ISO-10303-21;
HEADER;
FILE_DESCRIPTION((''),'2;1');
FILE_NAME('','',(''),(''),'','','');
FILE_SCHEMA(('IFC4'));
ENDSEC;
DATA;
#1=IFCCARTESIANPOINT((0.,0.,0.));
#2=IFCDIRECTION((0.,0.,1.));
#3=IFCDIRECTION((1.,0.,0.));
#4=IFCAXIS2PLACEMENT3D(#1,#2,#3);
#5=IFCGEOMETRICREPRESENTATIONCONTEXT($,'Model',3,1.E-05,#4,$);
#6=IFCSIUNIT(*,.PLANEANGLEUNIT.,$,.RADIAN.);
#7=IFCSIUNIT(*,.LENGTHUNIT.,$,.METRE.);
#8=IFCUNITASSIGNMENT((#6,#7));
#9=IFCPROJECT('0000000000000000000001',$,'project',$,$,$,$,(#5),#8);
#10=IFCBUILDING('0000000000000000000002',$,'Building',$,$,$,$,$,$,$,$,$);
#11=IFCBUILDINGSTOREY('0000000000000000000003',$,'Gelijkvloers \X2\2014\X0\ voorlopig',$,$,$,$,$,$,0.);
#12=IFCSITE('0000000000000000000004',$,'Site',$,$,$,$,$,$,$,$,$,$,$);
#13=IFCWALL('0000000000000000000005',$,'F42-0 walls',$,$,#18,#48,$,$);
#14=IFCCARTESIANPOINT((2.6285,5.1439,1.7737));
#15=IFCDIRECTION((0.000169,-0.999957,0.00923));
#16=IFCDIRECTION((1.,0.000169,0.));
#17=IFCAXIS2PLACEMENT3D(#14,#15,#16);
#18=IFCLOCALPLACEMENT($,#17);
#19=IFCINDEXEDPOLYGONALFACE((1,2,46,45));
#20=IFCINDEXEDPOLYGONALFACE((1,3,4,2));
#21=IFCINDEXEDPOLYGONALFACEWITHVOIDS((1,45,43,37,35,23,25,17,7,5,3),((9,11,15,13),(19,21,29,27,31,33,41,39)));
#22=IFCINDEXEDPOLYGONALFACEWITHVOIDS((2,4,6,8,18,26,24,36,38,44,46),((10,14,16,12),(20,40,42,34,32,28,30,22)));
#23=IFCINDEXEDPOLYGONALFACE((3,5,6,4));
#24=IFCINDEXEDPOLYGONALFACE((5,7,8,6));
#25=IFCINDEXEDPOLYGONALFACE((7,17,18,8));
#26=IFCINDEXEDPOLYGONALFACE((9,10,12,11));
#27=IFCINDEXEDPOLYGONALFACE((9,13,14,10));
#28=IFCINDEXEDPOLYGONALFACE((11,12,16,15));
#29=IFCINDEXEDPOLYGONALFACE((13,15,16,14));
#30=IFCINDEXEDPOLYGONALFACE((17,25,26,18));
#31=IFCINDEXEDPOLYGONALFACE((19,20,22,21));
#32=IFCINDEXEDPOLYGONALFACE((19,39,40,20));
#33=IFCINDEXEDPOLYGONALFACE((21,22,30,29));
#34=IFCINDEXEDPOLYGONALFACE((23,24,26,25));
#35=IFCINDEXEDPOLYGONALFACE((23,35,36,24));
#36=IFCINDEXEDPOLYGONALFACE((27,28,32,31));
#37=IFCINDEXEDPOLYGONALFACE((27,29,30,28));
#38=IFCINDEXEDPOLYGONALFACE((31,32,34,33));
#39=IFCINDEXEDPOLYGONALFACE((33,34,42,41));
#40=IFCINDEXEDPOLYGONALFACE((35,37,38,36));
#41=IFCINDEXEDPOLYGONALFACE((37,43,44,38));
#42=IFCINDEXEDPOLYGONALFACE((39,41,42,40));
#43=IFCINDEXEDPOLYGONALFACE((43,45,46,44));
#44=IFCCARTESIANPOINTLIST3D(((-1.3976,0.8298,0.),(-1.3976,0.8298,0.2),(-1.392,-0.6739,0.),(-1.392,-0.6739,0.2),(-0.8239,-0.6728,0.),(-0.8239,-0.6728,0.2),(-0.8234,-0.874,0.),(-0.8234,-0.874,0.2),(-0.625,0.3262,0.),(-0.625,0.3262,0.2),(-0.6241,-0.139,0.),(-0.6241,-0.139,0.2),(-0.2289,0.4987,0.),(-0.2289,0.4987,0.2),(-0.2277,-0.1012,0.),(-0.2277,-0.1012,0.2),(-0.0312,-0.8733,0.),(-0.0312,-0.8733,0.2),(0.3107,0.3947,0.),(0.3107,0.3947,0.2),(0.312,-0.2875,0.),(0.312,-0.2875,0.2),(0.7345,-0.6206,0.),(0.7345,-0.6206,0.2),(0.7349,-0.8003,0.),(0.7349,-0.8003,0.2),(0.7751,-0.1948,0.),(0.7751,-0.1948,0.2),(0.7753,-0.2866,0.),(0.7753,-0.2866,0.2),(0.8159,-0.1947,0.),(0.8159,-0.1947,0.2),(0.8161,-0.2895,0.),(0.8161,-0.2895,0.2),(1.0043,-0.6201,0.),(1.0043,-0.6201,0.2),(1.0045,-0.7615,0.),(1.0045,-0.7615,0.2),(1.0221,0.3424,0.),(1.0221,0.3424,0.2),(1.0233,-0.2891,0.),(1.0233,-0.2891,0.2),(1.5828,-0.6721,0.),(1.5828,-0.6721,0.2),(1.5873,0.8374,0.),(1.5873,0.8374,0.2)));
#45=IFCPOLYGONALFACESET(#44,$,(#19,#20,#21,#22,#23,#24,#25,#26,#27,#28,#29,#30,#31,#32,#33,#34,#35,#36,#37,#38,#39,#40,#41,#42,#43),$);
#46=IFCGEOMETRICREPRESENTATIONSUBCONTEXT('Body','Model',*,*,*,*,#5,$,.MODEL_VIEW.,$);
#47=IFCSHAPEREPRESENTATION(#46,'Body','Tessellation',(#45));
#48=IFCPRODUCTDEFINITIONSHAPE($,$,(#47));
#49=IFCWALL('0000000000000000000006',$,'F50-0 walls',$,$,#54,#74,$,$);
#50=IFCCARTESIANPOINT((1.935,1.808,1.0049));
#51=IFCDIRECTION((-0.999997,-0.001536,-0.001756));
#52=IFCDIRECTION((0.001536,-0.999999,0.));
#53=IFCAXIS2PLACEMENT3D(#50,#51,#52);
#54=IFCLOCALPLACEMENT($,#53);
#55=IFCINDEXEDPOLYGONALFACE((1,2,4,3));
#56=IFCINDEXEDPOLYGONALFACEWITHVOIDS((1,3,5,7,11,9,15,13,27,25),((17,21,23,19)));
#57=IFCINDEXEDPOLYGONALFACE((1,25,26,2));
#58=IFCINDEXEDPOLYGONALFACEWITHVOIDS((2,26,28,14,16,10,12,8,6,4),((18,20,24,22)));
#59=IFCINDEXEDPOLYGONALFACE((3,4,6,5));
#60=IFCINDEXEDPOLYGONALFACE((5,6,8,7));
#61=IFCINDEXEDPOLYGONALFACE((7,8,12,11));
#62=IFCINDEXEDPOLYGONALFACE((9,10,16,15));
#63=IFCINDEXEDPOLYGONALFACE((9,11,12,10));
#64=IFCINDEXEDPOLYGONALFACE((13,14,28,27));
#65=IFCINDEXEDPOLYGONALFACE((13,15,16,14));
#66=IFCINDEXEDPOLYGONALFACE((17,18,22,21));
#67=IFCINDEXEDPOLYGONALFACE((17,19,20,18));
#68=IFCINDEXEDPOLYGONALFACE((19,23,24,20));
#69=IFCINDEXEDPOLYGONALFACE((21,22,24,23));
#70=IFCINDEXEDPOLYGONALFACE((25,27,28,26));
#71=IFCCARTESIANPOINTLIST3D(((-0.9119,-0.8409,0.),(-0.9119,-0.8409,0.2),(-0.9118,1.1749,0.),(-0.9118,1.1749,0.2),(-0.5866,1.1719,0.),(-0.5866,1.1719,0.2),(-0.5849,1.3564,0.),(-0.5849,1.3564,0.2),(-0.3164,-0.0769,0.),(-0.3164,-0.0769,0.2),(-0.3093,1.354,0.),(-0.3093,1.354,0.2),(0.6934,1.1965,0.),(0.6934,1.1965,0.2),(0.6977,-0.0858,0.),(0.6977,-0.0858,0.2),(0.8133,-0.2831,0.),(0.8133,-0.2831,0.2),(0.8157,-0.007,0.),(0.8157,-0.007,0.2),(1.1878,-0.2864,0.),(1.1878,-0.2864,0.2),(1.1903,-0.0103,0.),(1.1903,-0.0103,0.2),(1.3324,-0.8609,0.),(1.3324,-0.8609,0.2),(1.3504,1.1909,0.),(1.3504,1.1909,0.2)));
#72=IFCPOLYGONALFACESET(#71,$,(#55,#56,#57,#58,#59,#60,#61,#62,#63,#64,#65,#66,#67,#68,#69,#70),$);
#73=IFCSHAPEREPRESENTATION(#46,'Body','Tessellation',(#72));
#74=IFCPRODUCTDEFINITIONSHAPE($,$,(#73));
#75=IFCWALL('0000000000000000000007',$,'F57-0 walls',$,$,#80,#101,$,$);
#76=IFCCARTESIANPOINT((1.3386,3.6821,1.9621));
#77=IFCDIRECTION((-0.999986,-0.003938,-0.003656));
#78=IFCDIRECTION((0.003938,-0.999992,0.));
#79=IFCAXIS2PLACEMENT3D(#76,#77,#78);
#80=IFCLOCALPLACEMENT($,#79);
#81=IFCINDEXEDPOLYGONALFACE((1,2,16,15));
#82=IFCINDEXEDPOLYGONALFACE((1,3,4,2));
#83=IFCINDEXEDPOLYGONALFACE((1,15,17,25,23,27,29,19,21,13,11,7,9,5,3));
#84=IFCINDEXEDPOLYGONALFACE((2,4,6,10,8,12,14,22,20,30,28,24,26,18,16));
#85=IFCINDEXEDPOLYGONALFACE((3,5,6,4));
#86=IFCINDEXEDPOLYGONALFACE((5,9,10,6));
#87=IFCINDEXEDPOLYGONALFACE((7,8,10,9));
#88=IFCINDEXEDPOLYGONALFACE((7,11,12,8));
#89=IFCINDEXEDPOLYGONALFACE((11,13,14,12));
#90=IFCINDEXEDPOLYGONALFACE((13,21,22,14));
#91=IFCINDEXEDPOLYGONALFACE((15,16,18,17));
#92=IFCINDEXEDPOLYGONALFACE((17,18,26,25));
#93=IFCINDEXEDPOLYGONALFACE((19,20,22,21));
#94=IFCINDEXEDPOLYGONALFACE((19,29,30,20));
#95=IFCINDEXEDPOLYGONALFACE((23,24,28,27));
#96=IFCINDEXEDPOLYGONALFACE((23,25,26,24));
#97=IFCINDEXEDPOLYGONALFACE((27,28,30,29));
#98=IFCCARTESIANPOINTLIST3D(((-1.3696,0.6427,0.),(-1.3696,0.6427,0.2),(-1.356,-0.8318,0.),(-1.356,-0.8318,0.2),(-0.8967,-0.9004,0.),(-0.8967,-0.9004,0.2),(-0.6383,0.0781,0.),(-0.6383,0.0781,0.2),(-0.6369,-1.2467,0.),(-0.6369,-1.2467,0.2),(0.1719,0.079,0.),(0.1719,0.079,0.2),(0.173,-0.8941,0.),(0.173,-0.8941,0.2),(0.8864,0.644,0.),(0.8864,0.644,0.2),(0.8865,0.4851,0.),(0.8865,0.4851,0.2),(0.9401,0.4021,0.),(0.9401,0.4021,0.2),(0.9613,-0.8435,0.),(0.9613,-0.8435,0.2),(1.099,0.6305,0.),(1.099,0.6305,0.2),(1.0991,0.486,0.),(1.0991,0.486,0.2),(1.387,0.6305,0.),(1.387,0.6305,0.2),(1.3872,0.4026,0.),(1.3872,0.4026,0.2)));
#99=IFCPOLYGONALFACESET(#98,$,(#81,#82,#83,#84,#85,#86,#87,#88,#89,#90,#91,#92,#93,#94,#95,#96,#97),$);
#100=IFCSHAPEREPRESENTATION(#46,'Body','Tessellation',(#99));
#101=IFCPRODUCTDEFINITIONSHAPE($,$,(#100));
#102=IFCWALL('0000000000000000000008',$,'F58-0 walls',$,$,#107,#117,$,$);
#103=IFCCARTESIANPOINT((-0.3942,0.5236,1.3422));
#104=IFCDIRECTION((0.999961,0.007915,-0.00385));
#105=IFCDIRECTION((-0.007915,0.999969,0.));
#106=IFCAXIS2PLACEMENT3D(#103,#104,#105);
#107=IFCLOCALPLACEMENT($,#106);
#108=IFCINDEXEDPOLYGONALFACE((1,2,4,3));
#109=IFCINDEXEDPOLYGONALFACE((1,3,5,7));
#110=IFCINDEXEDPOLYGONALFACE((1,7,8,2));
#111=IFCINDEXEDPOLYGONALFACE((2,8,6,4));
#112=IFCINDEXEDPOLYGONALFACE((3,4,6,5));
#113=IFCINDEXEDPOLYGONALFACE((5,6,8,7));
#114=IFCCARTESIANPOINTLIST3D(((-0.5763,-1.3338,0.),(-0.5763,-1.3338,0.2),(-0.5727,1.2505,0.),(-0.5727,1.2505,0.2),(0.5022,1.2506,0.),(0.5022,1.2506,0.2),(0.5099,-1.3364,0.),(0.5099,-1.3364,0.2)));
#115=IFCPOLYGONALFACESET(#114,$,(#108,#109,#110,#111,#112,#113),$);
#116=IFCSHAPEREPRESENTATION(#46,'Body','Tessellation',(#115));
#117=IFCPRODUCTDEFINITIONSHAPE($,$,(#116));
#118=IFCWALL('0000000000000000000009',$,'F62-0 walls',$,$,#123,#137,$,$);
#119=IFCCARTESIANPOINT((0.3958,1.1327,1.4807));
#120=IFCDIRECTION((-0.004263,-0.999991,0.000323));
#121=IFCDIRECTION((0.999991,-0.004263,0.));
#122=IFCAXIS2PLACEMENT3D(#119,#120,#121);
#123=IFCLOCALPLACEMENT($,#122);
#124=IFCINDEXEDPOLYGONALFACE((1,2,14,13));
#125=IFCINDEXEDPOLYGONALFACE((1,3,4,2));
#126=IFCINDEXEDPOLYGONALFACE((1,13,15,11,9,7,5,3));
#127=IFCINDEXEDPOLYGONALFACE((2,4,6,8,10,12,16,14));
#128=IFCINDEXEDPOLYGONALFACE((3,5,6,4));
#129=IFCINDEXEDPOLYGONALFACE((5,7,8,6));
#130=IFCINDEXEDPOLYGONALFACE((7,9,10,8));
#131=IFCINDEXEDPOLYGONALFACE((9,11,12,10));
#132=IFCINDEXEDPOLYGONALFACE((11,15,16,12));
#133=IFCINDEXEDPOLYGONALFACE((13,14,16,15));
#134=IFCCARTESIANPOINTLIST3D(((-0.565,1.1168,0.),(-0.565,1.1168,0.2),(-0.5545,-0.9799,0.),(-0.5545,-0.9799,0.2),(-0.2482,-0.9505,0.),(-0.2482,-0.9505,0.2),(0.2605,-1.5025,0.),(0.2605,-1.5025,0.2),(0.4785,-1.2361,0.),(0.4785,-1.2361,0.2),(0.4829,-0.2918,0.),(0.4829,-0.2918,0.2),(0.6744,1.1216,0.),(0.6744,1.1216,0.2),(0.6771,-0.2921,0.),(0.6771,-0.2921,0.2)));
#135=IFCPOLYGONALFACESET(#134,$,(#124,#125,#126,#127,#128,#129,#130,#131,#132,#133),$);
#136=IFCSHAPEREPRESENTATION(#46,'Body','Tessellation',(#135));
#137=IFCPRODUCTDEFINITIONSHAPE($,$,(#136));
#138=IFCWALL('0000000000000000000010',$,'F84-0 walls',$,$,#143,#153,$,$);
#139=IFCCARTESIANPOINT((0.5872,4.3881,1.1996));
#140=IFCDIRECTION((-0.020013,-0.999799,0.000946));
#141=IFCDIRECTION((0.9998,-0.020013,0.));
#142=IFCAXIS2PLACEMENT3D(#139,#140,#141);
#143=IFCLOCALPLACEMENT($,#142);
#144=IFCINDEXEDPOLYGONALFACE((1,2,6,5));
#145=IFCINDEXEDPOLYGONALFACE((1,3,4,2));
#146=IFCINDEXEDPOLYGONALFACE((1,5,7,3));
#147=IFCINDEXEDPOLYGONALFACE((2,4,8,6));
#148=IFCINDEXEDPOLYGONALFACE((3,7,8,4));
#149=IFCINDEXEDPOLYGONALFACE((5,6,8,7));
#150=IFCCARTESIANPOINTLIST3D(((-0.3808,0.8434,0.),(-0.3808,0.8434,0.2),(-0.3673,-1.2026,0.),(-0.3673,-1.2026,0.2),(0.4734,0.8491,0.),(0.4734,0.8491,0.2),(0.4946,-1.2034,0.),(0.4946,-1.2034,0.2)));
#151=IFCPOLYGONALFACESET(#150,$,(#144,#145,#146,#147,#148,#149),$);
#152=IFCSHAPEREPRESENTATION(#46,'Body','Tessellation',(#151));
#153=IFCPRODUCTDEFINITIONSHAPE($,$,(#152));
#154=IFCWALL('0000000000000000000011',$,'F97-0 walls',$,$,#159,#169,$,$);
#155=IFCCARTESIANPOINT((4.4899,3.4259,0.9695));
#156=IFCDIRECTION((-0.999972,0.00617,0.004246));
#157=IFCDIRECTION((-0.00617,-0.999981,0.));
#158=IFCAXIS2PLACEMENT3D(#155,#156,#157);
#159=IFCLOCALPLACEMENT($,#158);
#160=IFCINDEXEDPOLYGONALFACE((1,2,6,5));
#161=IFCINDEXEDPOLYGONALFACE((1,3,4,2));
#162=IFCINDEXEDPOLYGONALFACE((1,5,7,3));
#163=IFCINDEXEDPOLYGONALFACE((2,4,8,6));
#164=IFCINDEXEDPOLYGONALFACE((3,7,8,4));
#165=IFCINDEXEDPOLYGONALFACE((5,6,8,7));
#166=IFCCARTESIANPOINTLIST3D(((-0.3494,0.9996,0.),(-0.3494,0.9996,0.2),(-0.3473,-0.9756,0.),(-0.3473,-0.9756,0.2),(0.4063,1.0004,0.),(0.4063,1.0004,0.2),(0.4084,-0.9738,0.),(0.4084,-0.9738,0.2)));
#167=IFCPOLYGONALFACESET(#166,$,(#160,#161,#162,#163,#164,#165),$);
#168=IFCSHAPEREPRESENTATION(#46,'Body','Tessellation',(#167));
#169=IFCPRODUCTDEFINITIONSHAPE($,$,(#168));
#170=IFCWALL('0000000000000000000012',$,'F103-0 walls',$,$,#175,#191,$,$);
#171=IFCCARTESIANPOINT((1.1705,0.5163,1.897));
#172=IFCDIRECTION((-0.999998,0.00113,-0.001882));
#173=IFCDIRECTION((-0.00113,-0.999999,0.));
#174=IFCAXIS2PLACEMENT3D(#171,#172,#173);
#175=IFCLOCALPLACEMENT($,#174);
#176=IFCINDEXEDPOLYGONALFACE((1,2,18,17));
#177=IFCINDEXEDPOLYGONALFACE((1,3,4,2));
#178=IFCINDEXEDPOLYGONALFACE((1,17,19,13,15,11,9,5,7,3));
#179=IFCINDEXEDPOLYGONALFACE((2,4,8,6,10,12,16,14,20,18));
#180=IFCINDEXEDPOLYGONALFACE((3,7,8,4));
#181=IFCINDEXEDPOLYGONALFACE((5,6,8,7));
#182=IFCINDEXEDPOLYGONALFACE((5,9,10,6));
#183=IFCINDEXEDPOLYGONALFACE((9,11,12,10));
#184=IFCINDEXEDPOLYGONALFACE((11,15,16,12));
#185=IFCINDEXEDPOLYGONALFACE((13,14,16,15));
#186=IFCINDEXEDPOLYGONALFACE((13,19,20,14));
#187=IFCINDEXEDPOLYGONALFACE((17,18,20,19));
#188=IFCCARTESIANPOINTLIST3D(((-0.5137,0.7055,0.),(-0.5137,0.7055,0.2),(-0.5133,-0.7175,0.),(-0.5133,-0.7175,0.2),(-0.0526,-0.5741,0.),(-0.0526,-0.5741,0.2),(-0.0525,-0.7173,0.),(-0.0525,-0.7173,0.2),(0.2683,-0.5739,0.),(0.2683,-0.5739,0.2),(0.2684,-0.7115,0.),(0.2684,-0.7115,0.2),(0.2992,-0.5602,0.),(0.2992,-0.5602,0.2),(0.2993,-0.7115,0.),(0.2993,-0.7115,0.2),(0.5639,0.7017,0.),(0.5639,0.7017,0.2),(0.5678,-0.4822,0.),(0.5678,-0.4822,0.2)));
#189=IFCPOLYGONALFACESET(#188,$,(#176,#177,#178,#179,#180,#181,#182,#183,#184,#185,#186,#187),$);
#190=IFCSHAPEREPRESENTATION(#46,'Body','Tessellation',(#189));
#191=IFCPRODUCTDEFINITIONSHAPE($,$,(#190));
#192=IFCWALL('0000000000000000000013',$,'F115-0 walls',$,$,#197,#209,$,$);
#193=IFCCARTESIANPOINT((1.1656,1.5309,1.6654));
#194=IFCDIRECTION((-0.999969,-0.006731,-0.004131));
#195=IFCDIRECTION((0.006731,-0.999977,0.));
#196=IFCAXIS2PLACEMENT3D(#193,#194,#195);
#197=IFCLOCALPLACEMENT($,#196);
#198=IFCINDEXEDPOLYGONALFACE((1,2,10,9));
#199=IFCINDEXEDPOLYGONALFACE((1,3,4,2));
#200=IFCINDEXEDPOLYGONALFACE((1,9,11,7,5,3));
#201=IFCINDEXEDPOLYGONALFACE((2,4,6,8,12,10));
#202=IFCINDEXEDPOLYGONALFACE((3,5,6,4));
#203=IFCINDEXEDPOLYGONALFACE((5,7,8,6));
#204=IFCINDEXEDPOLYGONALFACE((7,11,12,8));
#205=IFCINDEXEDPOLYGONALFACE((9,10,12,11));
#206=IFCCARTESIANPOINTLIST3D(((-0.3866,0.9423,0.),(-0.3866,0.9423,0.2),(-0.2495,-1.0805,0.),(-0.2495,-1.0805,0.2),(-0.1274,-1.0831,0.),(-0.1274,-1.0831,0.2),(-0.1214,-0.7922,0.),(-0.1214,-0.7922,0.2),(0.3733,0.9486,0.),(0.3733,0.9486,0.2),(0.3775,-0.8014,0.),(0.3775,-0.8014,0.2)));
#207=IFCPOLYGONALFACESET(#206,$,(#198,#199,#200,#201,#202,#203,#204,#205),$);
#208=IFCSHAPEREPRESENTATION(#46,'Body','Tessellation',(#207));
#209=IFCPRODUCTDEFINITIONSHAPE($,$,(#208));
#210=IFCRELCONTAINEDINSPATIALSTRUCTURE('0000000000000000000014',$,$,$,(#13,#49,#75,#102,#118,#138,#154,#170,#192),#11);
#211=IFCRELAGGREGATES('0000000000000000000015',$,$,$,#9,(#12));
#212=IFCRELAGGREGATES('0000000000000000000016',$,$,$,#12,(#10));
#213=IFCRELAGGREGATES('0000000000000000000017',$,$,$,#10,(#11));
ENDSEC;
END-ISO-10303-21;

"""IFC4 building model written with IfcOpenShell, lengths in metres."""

from ifc_helpers import new_model, si_unit, frame, origin_with_axes, place, context, subcontext, project, spatial, polyline, outline, extrude, element, save


model = new_model("IFC4")

# Units and contexts
model_context = context("Model", 3, precision=1e-05, world=origin_with_axes())
body_context = subcontext(model_context, "Body", "Model", "MODEL_VIEW")
ifc_project = project(units=[si_unit("PLANEANGLEUNIT", "RADIAN"), si_unit("LENGTHUNIT", "METRE")], contexts=[model_context])

# Site, building, storey
site = spatial("IfcSite", under=ifc_project, Name="Site")
building = spatial("IfcBuilding", under=site, Name="Building")
storey = spatial("IfcBuildingStorey", under=building, Name="Gelijkvloers — voorlopig", Elevation=0.0)

# Wall, openings
wall_1_placement = place(None, frame((2.6285, 5.1439, 1.7737), z_axis=(0.000169, -0.999957, 0.00923), x_axis=(1.0, 0.000169, 0.0)))
wall_1 = element("IfcWall", 1, at=wall_1_placement, inside=storey, Name="F42-0 walls", context=body_context, shape_type="SweptSolid", body=[
    extrude(outline(polyline([(-0.0312, -0.8733), (0.7349, -0.8003), (0.7345, -0.6206), (1.0043, -0.6201), (1.0045, -0.7615), (1.5828, -0.6721), (1.5873, 0.8374), (-1.3976, 0.8298), (-1.392, -0.6739), (-0.8239, -0.6728), (-0.8234, -0.874), (-0.0312, -0.8733)])), origin_with_axes(), (0.0, 0.0, 1.0), 0.2),
])
opening_1_placement = place(wall_1_placement, frame((0.0, 0.0, -0.05), z_axis=(0.0, 0.0, 1.0), x_axis=(1.0, 0.0, 0.0)))
element("IfcOpeningElement", 2, at=opening_1_placement, cuts=wall_1, PredefinedType="OPENING", context=body_context, shape_type="SweptSolid", body=[
    extrude(outline(polyline([(0.3107, 0.3947), (1.0221, 0.3424), (1.0233, -0.2891), (0.8161, -0.2895), (0.8159, -0.1947), (0.7751, -0.1948), (0.7753, -0.2866), (0.312, -0.2875), (0.3107, 0.3947)])), origin_with_axes(), (0.0, 0.0, 1.0), 0.3),
])
opening_2_placement = place(wall_1_placement, frame((0.0, 0.0, -0.05), z_axis=(0.0, 0.0, 1.0), x_axis=(1.0, 0.0, 0.0)))
element("IfcOpeningElement", 3, at=opening_2_placement, cuts=wall_1, PredefinedType="OPENING", context=body_context, shape_type="SweptSolid", body=[
    extrude(outline(polyline([(-0.625, 0.3262), (-0.2289, 0.4987), (-0.2277, -0.1012), (-0.6241, -0.139), (-0.625, 0.3262)])), origin_with_axes(), (0.0, 0.0, 1.0), 0.3),
])

# Wall, opening
wall_2_placement = place(None, frame((1.935, 1.808, 1.0049), z_axis=(-0.999997, -0.001536, -0.001756), x_axis=(0.001536, -0.999999, 0.0)))
wall_2 = element("IfcWall", 4, at=wall_2_placement, inside=storey, Name="F50-0 walls", context=body_context, shape_type="SweptSolid", body=[
    extrude(outline(polyline([(-0.9119, -0.8409), (1.3324, -0.8609), (1.3504, 1.1909), (0.6934, 1.1965), (0.6977, -0.0858), (-0.3164, -0.0769), (-0.3093, 1.354), (-0.5849, 1.3564), (-0.5866, 1.1719), (-0.9118, 1.1749), (-0.9119, -0.8409)])), origin_with_axes(), (0.0, 0.0, 1.0), 0.2),
])
opening_3_placement = place(wall_2_placement, frame((0.0, 0.0, -0.05), z_axis=(0.0, 0.0, 1.0), x_axis=(1.0, 0.0, 0.0)))
element("IfcOpeningElement", 5, at=opening_3_placement, cuts=wall_2, PredefinedType="OPENING", context=body_context, shape_type="SweptSolid", body=[
    extrude(outline(polyline([(0.8133, -0.2831), (0.8157, -0.007), (1.1903, -0.0103), (1.1878, -0.2864), (0.8133, -0.2831)])), origin_with_axes(), (0.0, 0.0, 1.0), 0.3),
])

# Walls
wall_3_placement = place(None, frame((1.3386, 3.6821, 1.9621), z_axis=(-0.999986, -0.003938, -0.003656), x_axis=(0.003938, -0.999992, 0.0)))
element("IfcWall", 6, at=wall_3_placement, inside=storey, Name="F57-0 walls", context=body_context, shape_type="SweptSolid", body=[
    extrude(outline(polyline([(-0.6369, -1.2467), (-0.6383, 0.0781), (0.1719, 0.079), (0.173, -0.8941), (0.9613, -0.8435), (0.9401, 0.4021), (1.3872, 0.4026), (1.387, 0.6305), (1.099, 0.6305), (1.0991, 0.486), (0.8865, 0.4851), (0.8864, 0.644), (-1.3696, 0.6427), (-1.356, -0.8318), (-0.8967, -0.9004), (-0.6369, -1.2467)])), origin_with_axes(), (0.0, 0.0, 1.0), 0.2),
])
wall_4_placement = place(None, frame((-0.3942, 0.5236, 1.3422), z_axis=(0.999961, 0.007915, -0.00385), x_axis=(-0.007915, 0.999969, 0.0)))
element("IfcWall", 7, at=wall_4_placement, inside=storey, Name="F58-0 walls", context=body_context, shape_type="SweptSolid", body=[
    extrude(outline(polyline([(-0.5763, -1.3338), (0.5099, -1.3364), (0.5022, 1.2506), (-0.5727, 1.2505), (-0.5763, -1.3338)])), origin_with_axes(), (0.0, 0.0, 1.0), 0.2),
])
wall_5_placement = place(None, frame((0.3958, 1.1327, 1.4807), z_axis=(-0.004263, -0.999991, 0.000323), x_axis=(0.999991, -0.004263, 0.0)))
element("IfcWall", 8, at=wall_5_placement, inside=storey, Name="F62-0 walls", context=body_context, shape_type="SweptSolid", body=[
    extrude(outline(polyline([(0.2605, -1.5025), (0.4785, -1.2361), (0.4829, -0.2918), (0.6771, -0.2921), (0.6744, 1.1216), (-0.565, 1.1168), (-0.5545, -0.9799), (-0.2482, -0.9505), (0.2605, -1.5025)])), origin_with_axes(), (0.0, 0.0, 1.0), 0.2),
])
wall_6_placement = place(None, frame((0.5872, 4.3881, 1.1996), z_axis=(-0.020013, -0.999799, 0.000946), x_axis=(0.9998, -0.020013, 0.0)))
element("IfcWall", 9, at=wall_6_placement, inside=storey, Name="F84-0 walls", context=body_context, shape_type="SweptSolid", body=[
    extrude(outline(polyline([(-0.3673, -1.2026), (0.4946, -1.2034), (0.4734, 0.8491), (-0.3808, 0.8434), (-0.3673, -1.2026)])), origin_with_axes(), (0.0, 0.0, 1.0), 0.2),
])
wall_7_placement = place(None, frame((4.4899, 3.4259, 0.9695), z_axis=(-0.999972, 0.00617, 0.004246), x_axis=(-0.00617, -0.999981, 0.0)))
element("IfcWall", 10, at=wall_7_placement, inside=storey, Name="F97-0 walls", context=body_context, shape_type="SweptSolid", body=[
    extrude(outline(polyline([(-0.3473, -0.9756), (0.4084, -0.9738), (0.4063, 1.0004), (-0.3494, 0.9996), (-0.3473, -0.9756)])), origin_with_axes(), (0.0, 0.0, 1.0), 0.2),
])
wall_8_placement = place(None, frame((1.1705, 0.5163, 1.897), z_axis=(-0.999998, 0.00113, -0.001882), x_axis=(-0.00113, -0.999999, 0.0)))
element("IfcWall", 11, at=wall_8_placement, inside=storey, Name="F103-0 walls", context=body_context, shape_type="SweptSolid", body=[
    extrude(outline(polyline([(-0.5133, -0.7175), (-0.0525, -0.7173), (-0.0526, -0.5741), (0.2683, -0.5739), (0.2684, -0.7115), (0.2993, -0.7115), (0.2992, -0.5602), (0.5678, -0.4822), (0.5639, 0.7017), (-0.5137, 0.7055), (-0.5133, -0.7175)])), origin_with_axes(), (0.0, 0.0, 1.0), 0.2),
])
wall_9_placement = place(None, frame((1.1656, 1.5309, 1.6654), z_axis=(-0.999969, -0.006731, -0.004131), x_axis=(0.006731, -0.999977, 0.0)))
element("IfcWall", 12, at=wall_9_placement, inside=storey, Name="F115-0 walls", context=body_context, shape_type="SweptSolid", body=[
    extrude(outline(polyline([(-0.2495, -1.0805), (-0.1274, -1.0831), (-0.1214, -0.7922), (0.3775, -0.8014), (0.3733, 0.9486), (-0.3866, 0.9423), (-0.2495, -1.0805)])), origin_with_axes(), (0.0, 0.0, 1.0), 0.2),
])

save(model, "model.ifc")
